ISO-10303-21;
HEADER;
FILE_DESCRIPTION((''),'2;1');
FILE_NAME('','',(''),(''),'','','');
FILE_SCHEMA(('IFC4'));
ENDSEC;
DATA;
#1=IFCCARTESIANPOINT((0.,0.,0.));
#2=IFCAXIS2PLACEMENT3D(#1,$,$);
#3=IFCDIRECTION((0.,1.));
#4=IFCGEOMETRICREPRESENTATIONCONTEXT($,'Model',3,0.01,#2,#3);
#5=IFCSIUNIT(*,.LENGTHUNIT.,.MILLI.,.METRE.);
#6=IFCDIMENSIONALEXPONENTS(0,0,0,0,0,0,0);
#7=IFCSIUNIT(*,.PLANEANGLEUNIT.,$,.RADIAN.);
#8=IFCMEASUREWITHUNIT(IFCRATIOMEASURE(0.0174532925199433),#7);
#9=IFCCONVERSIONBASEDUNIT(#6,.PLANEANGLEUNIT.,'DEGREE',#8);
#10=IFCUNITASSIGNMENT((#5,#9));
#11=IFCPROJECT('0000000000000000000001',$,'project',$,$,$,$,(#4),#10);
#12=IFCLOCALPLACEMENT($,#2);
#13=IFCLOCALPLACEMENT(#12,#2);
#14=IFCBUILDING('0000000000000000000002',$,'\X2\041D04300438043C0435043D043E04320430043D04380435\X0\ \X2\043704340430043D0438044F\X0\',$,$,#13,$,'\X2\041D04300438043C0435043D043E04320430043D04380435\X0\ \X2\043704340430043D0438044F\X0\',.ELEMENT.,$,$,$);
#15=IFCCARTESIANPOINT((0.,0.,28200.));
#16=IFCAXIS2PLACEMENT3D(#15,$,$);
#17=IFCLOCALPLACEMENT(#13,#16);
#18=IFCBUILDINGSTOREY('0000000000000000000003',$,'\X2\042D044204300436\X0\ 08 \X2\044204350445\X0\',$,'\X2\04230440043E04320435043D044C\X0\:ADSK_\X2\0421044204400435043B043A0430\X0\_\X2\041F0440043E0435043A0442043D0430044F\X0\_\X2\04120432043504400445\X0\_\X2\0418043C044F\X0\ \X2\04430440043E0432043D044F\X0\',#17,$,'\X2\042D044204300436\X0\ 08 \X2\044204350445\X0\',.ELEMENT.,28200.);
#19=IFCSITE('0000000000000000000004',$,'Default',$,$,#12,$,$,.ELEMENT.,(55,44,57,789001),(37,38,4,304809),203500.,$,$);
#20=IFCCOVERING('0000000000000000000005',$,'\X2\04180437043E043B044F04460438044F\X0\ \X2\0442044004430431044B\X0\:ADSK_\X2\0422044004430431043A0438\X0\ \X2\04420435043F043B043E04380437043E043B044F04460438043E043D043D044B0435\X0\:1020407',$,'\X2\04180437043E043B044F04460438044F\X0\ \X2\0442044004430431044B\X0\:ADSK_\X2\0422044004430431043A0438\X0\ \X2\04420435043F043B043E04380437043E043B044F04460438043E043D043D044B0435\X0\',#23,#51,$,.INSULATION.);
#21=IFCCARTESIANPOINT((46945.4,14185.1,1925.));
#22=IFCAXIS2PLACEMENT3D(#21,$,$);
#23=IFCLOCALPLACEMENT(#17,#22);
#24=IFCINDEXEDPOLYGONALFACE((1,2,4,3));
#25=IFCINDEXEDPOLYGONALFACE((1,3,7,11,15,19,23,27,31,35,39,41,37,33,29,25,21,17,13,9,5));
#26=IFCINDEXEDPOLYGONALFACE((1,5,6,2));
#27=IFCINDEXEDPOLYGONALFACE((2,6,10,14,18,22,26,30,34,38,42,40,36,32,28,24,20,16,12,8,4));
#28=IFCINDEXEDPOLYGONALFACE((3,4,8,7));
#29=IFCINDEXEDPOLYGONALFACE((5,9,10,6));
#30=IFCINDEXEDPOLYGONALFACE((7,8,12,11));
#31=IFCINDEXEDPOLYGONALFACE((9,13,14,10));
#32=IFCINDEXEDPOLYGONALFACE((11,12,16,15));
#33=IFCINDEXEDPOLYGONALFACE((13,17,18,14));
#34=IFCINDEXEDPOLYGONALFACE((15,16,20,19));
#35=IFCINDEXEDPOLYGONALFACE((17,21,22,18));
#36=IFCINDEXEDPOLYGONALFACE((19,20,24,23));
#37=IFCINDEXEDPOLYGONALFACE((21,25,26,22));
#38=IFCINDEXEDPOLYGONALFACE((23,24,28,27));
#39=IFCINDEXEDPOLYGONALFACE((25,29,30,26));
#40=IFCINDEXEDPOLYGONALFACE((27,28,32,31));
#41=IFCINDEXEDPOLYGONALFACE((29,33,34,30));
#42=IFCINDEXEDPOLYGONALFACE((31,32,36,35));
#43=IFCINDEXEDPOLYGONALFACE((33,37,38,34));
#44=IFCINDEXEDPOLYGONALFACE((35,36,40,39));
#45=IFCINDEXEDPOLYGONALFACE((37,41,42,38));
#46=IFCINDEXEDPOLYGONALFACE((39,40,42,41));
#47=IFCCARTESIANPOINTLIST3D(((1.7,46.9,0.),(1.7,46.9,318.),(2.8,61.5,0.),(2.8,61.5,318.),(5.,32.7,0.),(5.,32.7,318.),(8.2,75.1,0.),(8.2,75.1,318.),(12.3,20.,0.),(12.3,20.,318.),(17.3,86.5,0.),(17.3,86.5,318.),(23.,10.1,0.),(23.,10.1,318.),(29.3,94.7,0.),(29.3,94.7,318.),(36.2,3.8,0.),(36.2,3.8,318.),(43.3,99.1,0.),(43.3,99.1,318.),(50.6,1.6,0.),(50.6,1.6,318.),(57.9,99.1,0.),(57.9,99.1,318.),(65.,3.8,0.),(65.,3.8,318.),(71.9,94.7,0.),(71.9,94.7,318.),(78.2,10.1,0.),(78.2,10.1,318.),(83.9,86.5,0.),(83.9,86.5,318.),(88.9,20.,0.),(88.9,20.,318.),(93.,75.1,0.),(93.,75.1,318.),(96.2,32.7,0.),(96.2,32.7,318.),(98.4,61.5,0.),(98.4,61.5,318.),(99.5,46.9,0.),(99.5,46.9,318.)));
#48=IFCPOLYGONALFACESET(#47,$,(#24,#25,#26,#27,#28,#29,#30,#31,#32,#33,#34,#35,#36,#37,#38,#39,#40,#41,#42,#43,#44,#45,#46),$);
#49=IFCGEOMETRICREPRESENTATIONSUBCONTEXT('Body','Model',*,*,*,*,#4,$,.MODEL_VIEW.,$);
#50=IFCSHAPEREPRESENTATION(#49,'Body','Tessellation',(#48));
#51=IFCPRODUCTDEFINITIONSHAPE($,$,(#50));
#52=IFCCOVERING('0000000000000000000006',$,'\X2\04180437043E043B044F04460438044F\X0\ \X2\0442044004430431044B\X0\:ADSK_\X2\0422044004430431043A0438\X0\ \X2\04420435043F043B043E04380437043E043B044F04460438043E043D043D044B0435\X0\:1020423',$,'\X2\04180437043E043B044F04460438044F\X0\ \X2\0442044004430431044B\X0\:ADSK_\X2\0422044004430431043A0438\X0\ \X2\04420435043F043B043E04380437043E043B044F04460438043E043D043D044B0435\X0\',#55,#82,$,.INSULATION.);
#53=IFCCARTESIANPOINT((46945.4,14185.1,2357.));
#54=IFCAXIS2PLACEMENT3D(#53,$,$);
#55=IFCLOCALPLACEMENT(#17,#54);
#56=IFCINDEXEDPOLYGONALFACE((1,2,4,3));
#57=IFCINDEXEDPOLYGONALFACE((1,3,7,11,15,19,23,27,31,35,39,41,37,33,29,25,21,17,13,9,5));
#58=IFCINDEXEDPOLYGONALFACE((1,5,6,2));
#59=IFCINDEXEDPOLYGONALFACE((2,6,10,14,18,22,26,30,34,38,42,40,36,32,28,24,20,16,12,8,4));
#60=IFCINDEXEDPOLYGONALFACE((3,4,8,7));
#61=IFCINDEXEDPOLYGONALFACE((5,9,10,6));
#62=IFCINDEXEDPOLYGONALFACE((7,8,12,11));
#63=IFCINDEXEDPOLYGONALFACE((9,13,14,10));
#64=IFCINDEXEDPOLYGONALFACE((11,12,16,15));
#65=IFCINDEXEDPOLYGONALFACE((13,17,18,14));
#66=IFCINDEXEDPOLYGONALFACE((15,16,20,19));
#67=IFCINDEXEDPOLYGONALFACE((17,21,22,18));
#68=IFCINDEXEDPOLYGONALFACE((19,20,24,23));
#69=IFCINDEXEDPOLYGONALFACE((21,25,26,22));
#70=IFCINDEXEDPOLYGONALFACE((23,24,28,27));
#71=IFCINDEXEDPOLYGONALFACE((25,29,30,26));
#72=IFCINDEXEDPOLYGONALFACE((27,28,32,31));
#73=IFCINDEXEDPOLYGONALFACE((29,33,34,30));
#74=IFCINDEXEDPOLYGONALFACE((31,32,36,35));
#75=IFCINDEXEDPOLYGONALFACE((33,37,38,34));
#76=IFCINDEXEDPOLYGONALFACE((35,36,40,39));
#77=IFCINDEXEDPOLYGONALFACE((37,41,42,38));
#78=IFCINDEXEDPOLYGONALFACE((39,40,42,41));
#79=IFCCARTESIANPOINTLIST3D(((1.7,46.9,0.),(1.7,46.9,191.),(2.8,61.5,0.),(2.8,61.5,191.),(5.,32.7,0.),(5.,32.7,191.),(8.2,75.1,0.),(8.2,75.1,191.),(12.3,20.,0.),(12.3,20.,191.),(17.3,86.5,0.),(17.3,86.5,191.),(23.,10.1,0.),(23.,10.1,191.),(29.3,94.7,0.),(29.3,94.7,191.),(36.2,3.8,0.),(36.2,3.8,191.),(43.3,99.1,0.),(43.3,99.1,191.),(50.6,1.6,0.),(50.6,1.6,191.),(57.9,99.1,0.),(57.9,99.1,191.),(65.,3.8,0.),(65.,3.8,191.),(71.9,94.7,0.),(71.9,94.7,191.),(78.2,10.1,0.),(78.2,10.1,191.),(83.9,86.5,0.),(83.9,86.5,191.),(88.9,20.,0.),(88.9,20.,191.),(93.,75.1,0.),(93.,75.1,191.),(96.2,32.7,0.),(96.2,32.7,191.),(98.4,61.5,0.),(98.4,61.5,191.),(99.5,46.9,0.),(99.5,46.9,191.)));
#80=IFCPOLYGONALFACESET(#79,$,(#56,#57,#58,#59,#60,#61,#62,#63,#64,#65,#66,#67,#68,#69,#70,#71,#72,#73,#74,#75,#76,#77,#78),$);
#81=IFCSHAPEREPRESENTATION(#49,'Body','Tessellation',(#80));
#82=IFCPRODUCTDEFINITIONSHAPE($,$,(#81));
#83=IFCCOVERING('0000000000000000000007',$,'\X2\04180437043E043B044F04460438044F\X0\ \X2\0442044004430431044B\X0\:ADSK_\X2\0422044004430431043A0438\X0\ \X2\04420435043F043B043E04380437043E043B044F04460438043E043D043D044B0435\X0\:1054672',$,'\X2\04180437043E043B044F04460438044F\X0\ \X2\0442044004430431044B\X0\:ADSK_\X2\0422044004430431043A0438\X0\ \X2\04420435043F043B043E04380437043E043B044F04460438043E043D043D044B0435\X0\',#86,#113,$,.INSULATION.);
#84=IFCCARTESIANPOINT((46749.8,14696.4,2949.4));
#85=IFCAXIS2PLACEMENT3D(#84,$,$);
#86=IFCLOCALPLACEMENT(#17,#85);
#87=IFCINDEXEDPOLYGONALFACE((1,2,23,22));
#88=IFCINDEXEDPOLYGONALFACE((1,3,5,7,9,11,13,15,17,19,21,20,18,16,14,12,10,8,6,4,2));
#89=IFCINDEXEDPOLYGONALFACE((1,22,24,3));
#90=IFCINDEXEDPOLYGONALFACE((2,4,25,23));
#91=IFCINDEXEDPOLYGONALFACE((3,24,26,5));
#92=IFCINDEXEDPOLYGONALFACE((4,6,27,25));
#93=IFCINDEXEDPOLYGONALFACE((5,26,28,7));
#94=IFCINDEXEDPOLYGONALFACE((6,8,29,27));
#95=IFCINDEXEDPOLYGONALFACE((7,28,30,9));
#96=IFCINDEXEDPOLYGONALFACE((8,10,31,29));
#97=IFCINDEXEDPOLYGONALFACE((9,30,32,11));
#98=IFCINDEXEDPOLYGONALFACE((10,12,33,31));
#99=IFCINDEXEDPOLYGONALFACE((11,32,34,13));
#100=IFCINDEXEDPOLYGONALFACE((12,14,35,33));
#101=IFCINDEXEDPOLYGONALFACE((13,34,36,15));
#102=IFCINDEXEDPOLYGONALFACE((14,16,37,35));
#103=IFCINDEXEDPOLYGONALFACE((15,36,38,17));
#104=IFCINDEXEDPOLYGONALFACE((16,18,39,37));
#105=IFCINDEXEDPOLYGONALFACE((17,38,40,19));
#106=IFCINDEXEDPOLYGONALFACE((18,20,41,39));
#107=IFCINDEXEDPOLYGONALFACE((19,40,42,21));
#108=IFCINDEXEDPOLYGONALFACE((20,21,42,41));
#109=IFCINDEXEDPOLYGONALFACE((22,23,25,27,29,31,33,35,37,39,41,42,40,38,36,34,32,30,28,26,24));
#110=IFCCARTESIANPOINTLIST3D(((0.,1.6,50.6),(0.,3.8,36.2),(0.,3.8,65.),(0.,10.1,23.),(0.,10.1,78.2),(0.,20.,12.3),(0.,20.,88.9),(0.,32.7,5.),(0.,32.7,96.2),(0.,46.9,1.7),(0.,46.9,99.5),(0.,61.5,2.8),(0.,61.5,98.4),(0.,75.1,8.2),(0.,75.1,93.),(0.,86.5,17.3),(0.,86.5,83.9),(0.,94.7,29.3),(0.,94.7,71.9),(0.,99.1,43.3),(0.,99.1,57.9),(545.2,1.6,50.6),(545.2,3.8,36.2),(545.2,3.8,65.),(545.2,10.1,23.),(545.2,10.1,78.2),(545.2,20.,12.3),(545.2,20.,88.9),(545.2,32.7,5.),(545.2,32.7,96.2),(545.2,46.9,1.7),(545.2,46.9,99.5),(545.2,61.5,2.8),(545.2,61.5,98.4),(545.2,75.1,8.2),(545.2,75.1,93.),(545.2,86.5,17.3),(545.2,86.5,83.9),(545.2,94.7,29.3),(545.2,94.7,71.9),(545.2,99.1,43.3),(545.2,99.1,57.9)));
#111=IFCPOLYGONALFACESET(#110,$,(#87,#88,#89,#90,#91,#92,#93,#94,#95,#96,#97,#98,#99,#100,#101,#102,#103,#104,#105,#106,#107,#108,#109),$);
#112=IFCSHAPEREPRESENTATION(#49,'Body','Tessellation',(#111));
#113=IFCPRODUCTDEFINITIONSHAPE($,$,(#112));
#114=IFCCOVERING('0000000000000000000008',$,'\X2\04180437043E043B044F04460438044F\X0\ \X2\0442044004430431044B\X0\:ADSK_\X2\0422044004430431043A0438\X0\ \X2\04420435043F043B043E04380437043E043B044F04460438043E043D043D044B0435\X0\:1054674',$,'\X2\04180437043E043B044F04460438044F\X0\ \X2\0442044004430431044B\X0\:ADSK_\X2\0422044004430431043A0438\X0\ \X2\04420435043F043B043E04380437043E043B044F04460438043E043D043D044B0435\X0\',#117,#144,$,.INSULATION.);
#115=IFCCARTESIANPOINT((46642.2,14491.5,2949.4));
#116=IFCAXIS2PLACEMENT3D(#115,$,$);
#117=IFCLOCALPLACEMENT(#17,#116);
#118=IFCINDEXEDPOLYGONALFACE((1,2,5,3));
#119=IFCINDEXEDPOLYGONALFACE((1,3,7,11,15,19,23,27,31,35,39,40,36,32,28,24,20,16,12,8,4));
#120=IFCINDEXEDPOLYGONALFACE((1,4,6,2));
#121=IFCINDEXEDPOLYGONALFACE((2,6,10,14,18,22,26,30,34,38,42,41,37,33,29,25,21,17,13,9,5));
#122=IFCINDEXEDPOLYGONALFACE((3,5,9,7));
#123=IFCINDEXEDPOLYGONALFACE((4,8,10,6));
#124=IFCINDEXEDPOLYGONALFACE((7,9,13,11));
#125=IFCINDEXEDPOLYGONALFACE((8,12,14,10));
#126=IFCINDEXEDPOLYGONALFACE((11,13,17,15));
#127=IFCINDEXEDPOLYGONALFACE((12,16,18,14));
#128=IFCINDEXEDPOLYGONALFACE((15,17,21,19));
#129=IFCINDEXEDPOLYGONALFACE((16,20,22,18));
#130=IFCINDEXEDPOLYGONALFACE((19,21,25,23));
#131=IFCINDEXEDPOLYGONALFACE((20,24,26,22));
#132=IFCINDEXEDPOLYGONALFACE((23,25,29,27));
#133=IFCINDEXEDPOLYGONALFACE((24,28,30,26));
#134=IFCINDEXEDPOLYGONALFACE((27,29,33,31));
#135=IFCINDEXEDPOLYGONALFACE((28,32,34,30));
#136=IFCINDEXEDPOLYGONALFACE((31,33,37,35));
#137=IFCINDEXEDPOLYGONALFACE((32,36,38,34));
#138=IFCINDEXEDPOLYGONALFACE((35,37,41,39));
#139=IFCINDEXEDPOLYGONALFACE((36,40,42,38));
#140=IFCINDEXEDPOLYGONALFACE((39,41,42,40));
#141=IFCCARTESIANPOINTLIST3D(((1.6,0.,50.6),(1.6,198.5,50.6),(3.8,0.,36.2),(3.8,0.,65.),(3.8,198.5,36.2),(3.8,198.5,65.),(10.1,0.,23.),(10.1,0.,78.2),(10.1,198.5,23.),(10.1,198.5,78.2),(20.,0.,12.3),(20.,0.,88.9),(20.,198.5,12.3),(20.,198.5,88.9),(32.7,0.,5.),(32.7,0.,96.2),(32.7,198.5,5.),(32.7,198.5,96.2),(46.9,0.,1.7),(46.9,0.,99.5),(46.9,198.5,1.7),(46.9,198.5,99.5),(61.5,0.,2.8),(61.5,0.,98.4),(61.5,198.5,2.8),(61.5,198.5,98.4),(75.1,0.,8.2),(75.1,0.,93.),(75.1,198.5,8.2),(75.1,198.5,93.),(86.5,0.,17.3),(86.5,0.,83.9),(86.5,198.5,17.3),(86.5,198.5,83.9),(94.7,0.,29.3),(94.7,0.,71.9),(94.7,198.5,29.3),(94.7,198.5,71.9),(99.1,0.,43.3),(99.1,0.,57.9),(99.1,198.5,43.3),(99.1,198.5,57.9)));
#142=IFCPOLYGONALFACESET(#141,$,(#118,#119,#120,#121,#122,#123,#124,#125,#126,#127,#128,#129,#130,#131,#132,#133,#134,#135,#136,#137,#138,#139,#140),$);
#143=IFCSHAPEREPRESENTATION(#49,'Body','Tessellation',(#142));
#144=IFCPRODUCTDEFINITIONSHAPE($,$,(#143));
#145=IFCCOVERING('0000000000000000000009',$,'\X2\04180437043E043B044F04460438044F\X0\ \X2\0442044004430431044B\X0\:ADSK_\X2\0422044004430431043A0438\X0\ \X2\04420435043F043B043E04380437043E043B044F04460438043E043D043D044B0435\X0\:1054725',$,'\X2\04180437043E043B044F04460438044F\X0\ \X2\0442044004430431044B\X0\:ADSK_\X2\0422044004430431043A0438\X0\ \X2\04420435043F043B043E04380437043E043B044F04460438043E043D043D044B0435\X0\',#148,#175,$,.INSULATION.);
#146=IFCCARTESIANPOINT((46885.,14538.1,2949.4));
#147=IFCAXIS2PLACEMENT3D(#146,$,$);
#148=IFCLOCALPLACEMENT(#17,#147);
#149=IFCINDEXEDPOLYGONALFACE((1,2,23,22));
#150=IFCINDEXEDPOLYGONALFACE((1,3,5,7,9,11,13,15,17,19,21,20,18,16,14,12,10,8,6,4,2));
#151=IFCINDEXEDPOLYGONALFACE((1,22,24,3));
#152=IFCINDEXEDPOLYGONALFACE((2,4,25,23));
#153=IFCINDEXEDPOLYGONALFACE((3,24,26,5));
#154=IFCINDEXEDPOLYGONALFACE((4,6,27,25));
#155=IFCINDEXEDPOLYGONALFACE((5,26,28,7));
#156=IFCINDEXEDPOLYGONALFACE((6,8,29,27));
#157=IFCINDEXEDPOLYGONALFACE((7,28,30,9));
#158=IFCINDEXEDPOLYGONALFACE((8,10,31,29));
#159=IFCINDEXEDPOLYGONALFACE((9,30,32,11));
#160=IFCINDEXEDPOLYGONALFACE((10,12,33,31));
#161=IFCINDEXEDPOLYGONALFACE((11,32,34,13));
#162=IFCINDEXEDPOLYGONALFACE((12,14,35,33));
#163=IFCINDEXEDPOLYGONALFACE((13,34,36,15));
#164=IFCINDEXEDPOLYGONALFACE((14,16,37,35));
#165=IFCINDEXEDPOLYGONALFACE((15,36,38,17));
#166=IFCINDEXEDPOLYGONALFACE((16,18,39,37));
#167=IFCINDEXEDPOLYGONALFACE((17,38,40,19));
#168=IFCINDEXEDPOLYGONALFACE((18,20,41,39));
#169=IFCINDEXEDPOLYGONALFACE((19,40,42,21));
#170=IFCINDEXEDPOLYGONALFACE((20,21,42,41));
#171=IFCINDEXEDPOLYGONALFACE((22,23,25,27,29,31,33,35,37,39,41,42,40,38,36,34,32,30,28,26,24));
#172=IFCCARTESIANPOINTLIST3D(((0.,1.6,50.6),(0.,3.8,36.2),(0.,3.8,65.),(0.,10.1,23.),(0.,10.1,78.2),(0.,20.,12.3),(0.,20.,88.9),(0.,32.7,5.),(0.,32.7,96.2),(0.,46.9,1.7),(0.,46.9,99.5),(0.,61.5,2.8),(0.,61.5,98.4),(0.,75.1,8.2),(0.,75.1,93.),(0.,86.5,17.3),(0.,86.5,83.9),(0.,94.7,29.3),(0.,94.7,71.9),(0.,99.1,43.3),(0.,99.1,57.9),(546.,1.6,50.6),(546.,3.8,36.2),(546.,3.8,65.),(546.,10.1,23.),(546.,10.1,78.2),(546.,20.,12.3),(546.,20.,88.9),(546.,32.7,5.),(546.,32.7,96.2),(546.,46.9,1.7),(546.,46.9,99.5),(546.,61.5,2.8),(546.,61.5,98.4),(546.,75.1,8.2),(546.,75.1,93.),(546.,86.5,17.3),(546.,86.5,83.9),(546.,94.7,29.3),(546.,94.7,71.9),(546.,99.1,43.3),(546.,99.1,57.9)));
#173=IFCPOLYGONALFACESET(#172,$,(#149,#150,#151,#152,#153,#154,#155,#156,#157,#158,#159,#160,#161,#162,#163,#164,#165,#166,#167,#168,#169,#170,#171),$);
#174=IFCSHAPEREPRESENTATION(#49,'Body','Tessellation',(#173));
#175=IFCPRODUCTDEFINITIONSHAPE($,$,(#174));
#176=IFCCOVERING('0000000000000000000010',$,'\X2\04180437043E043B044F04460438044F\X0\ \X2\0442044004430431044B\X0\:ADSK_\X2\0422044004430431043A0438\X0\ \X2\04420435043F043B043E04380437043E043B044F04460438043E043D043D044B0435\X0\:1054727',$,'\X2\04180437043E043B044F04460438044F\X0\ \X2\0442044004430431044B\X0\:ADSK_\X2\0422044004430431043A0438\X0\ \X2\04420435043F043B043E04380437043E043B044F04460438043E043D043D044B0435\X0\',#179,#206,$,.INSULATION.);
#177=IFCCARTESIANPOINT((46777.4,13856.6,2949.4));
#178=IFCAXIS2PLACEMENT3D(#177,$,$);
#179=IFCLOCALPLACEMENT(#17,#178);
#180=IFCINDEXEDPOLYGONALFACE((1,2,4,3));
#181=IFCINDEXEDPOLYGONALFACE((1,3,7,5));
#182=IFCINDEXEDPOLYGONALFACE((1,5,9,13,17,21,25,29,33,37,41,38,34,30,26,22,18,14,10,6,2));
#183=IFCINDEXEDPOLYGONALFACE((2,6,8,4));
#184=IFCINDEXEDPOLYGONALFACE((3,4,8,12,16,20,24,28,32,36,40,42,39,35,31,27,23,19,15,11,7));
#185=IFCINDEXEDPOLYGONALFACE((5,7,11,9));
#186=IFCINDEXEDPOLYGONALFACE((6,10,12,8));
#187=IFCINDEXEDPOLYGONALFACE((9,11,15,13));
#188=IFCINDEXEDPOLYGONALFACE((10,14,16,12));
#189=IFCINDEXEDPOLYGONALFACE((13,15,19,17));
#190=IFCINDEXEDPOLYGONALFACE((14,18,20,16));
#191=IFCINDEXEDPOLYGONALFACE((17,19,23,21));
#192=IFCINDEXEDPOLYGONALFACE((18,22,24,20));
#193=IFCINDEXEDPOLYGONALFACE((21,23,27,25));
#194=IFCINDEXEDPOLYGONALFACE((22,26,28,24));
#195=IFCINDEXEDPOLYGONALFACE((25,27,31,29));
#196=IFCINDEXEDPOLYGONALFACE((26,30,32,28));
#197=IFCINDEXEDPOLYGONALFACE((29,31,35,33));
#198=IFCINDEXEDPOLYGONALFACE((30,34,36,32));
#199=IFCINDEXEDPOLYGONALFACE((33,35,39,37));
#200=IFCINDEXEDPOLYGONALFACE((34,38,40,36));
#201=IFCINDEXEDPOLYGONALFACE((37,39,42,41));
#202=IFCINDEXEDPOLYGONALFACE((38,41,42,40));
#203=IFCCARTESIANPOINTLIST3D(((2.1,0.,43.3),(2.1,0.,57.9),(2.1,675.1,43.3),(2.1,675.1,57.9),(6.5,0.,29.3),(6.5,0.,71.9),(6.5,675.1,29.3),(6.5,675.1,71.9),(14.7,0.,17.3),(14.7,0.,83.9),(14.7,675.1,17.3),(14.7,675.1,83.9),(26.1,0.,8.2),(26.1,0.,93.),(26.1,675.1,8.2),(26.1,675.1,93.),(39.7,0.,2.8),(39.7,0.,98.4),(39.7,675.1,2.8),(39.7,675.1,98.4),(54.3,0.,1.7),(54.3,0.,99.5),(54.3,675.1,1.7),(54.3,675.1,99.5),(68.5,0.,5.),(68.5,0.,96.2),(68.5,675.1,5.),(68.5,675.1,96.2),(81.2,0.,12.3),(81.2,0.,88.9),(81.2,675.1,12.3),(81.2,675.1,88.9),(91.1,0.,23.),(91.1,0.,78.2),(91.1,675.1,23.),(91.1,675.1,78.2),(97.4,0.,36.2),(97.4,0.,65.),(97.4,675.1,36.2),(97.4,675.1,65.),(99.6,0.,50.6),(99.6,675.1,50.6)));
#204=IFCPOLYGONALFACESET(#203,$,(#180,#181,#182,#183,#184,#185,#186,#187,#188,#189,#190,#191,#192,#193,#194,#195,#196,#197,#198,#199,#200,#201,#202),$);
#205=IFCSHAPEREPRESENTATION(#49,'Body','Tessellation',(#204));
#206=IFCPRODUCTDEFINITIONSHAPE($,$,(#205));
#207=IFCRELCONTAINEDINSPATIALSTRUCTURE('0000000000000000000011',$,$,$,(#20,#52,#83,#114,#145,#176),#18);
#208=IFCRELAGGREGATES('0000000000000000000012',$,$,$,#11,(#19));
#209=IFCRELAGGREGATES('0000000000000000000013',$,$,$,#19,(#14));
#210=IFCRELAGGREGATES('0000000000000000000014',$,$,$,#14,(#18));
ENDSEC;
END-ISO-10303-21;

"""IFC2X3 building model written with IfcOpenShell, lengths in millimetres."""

from ifc_helpers import new_model, entity, si_unit, converted_unit, direction, frame, origin, origin_2d_with_axis, place, context, subcontext, project, spatial, circle, extrude, element, save


model = new_model("IFC2X3")

# Units and contexts
model_context = context("Model", 3, precision=0.01, world=origin(), true_north=direction((0.0, 1.0)))
body_context = subcontext(model_context, "Body", "Model", "MODEL_VIEW")
ifc_project = project(units=[si_unit("LENGTHUNIT", "METRE", prefix="MILLI"), converted_unit("PLANEANGLEUNIT", "DEGREE", entity("IfcRatioMeasure", 0.0174532925199433), si_unit("PLANEANGLEUNIT", "RADIAN"), dimensions=[0, 0, 0, 0, 0, 0, 0])], contexts=[model_context])

# Site, building, storey
site_placement = place(None, origin())
site = spatial("IfcSite", under=ifc_project, at=site_placement, Name="Default", CompositionType="ELEMENT", RefLatitude=(55, 44, 57, 789001), RefLongitude=(37, 38, 4, 304809), RefElevation=203500.0)
building_placement = place(site_placement, origin())
building = spatial("IfcBuilding", under=site, at=building_placement, Name="Наименование здания", LongName="Наименование здания", CompositionType="ELEMENT")
storey_placement = place(building_placement, frame((0.0, 0.0, 28200.0)))
storey = spatial("IfcBuildingStorey", under=building, at=storey_placement, Name="Этаж 08 тех", ObjectType="Уровень:ADSK_Стрелка_Проектная_Вверх_Имя уровня", LongName="Этаж 08 тех", CompositionType="ELEMENT", Elevation=28200.0)

# Coverings
covering_1_placement = place(storey_placement, frame((46945.4, 14185.1, 1925.0)))
element("IfcCovering", 1, at=covering_1_placement, inside=storey, Name="Изоляция трубы:ADSK_Трубки теплоизоляционные:1020407", ObjectType="Изоляция трубы:ADSK_Трубки теплоизоляционные", PredefinedType="INSULATION", context=body_context, shape_type="SweptSolid", body=[
    extrude(circle(Radius=49.0, at=origin_2d_with_axis()), frame((50.6, 50.6, 0.0), z_axis=(0.0, 0.0, 1.0), x_axis=(0.0, -1.0, 0.0)), (0.0, 0.0, 1.0), 318.0),
])
covering_2_placement = place(storey_placement, frame((46945.4, 14185.1, 2357.0)))
element("IfcCovering", 2, at=covering_2_placement, inside=storey, Name="Изоляция трубы:ADSK_Трубки теплоизоляционные:1020423", ObjectType="Изоляция трубы:ADSK_Трубки теплоизоляционные", PredefinedType="INSULATION", context=body_context, shape_type="SweptSolid", body=[
    extrude(circle(Radius=49.0, at=origin_2d_with_axis()), frame((50.6, 50.6, 0.0), z_axis=(0.0, 0.0, 1.0), x_axis=(0.0, -1.0, 0.0)), (0.0, 0.0, 1.0), 191.0),
])
covering_3_placement = place(storey_placement, frame((46749.8, 14696.4, 2949.4)))
element("IfcCovering", 3, at=covering_3_placement, inside=storey, Name="Изоляция трубы:ADSK_Трубки теплоизоляционные:1054672", ObjectType="Изоляция трубы:ADSK_Трубки теплоизоляционные", PredefinedType="INSULATION", context=body_context, shape_type="SweptSolid", body=[
    extrude(circle(Radius=49.0, at=origin_2d_with_axis()), frame((0.0, 50.6, 50.6), z_axis=(1.0, 0.0, 0.0), x_axis=(0.0, -1.0, 0.0)), (0.0, 0.0, 1.0), 545.2),
])
covering_4_placement = place(storey_placement, frame((46642.2, 14491.5, 2949.4)))
element("IfcCovering", 4, at=covering_4_placement, inside=storey, Name="Изоляция трубы:ADSK_Трубки теплоизоляционные:1054674", ObjectType="Изоляция трубы:ADSK_Трубки теплоизоляционные", PredefinedType="INSULATION", context=body_context, shape_type="SweptSolid", body=[
    extrude(circle(Radius=49.0, at=origin_2d_with_axis()), frame((50.6, 0.0, 50.6), z_axis=(0.0, 1.0, 0.0), x_axis=(-1.0, 0.0, 0.0)), (0.0, 0.0, 1.0), 198.5),
])
covering_5_placement = place(storey_placement, frame((46885.0, 14538.1, 2949.4)))
element("IfcCovering", 5, at=covering_5_placement, inside=storey, Name="Изоляция трубы:ADSK_Трубки теплоизоляционные:1054725", ObjectType="Изоляция трубы:ADSK_Трубки теплоизоляционные", PredefinedType="INSULATION", context=body_context, shape_type="SweptSolid", body=[
    extrude(circle(Radius=49.0, at=origin_2d_with_axis()), frame((0.0, 50.6, 50.6), z_axis=(1.0, 0.0, 0.0), x_axis=(0.0, -1.0, 0.0)), (0.0, 0.0, 1.0), 546.0),
])
covering_6_placement = place(storey_placement, frame((46777.4, 13856.6, 2949.4)))
element("IfcCovering", 6, at=covering_6_placement, inside=storey, Name="Изоляция трубы:ADSK_Трубки теплоизоляционные:1054727", ObjectType="Изоляция трубы:ADSK_Трубки теплоизоляционные", PredefinedType="INSULATION", context=body_context, shape_type="SweptSolid", body=[
    extrude(circle(Radius=49.0, at=origin_2d_with_axis()), frame((50.6, 0.0, 50.6), z_axis=(0.0, 1.0, 0.0), x_axis=(1.0, 0.0, 0.0)), (0.0, 0.0, 1.0), 675.1),
])

save(model, "model.ifc")
